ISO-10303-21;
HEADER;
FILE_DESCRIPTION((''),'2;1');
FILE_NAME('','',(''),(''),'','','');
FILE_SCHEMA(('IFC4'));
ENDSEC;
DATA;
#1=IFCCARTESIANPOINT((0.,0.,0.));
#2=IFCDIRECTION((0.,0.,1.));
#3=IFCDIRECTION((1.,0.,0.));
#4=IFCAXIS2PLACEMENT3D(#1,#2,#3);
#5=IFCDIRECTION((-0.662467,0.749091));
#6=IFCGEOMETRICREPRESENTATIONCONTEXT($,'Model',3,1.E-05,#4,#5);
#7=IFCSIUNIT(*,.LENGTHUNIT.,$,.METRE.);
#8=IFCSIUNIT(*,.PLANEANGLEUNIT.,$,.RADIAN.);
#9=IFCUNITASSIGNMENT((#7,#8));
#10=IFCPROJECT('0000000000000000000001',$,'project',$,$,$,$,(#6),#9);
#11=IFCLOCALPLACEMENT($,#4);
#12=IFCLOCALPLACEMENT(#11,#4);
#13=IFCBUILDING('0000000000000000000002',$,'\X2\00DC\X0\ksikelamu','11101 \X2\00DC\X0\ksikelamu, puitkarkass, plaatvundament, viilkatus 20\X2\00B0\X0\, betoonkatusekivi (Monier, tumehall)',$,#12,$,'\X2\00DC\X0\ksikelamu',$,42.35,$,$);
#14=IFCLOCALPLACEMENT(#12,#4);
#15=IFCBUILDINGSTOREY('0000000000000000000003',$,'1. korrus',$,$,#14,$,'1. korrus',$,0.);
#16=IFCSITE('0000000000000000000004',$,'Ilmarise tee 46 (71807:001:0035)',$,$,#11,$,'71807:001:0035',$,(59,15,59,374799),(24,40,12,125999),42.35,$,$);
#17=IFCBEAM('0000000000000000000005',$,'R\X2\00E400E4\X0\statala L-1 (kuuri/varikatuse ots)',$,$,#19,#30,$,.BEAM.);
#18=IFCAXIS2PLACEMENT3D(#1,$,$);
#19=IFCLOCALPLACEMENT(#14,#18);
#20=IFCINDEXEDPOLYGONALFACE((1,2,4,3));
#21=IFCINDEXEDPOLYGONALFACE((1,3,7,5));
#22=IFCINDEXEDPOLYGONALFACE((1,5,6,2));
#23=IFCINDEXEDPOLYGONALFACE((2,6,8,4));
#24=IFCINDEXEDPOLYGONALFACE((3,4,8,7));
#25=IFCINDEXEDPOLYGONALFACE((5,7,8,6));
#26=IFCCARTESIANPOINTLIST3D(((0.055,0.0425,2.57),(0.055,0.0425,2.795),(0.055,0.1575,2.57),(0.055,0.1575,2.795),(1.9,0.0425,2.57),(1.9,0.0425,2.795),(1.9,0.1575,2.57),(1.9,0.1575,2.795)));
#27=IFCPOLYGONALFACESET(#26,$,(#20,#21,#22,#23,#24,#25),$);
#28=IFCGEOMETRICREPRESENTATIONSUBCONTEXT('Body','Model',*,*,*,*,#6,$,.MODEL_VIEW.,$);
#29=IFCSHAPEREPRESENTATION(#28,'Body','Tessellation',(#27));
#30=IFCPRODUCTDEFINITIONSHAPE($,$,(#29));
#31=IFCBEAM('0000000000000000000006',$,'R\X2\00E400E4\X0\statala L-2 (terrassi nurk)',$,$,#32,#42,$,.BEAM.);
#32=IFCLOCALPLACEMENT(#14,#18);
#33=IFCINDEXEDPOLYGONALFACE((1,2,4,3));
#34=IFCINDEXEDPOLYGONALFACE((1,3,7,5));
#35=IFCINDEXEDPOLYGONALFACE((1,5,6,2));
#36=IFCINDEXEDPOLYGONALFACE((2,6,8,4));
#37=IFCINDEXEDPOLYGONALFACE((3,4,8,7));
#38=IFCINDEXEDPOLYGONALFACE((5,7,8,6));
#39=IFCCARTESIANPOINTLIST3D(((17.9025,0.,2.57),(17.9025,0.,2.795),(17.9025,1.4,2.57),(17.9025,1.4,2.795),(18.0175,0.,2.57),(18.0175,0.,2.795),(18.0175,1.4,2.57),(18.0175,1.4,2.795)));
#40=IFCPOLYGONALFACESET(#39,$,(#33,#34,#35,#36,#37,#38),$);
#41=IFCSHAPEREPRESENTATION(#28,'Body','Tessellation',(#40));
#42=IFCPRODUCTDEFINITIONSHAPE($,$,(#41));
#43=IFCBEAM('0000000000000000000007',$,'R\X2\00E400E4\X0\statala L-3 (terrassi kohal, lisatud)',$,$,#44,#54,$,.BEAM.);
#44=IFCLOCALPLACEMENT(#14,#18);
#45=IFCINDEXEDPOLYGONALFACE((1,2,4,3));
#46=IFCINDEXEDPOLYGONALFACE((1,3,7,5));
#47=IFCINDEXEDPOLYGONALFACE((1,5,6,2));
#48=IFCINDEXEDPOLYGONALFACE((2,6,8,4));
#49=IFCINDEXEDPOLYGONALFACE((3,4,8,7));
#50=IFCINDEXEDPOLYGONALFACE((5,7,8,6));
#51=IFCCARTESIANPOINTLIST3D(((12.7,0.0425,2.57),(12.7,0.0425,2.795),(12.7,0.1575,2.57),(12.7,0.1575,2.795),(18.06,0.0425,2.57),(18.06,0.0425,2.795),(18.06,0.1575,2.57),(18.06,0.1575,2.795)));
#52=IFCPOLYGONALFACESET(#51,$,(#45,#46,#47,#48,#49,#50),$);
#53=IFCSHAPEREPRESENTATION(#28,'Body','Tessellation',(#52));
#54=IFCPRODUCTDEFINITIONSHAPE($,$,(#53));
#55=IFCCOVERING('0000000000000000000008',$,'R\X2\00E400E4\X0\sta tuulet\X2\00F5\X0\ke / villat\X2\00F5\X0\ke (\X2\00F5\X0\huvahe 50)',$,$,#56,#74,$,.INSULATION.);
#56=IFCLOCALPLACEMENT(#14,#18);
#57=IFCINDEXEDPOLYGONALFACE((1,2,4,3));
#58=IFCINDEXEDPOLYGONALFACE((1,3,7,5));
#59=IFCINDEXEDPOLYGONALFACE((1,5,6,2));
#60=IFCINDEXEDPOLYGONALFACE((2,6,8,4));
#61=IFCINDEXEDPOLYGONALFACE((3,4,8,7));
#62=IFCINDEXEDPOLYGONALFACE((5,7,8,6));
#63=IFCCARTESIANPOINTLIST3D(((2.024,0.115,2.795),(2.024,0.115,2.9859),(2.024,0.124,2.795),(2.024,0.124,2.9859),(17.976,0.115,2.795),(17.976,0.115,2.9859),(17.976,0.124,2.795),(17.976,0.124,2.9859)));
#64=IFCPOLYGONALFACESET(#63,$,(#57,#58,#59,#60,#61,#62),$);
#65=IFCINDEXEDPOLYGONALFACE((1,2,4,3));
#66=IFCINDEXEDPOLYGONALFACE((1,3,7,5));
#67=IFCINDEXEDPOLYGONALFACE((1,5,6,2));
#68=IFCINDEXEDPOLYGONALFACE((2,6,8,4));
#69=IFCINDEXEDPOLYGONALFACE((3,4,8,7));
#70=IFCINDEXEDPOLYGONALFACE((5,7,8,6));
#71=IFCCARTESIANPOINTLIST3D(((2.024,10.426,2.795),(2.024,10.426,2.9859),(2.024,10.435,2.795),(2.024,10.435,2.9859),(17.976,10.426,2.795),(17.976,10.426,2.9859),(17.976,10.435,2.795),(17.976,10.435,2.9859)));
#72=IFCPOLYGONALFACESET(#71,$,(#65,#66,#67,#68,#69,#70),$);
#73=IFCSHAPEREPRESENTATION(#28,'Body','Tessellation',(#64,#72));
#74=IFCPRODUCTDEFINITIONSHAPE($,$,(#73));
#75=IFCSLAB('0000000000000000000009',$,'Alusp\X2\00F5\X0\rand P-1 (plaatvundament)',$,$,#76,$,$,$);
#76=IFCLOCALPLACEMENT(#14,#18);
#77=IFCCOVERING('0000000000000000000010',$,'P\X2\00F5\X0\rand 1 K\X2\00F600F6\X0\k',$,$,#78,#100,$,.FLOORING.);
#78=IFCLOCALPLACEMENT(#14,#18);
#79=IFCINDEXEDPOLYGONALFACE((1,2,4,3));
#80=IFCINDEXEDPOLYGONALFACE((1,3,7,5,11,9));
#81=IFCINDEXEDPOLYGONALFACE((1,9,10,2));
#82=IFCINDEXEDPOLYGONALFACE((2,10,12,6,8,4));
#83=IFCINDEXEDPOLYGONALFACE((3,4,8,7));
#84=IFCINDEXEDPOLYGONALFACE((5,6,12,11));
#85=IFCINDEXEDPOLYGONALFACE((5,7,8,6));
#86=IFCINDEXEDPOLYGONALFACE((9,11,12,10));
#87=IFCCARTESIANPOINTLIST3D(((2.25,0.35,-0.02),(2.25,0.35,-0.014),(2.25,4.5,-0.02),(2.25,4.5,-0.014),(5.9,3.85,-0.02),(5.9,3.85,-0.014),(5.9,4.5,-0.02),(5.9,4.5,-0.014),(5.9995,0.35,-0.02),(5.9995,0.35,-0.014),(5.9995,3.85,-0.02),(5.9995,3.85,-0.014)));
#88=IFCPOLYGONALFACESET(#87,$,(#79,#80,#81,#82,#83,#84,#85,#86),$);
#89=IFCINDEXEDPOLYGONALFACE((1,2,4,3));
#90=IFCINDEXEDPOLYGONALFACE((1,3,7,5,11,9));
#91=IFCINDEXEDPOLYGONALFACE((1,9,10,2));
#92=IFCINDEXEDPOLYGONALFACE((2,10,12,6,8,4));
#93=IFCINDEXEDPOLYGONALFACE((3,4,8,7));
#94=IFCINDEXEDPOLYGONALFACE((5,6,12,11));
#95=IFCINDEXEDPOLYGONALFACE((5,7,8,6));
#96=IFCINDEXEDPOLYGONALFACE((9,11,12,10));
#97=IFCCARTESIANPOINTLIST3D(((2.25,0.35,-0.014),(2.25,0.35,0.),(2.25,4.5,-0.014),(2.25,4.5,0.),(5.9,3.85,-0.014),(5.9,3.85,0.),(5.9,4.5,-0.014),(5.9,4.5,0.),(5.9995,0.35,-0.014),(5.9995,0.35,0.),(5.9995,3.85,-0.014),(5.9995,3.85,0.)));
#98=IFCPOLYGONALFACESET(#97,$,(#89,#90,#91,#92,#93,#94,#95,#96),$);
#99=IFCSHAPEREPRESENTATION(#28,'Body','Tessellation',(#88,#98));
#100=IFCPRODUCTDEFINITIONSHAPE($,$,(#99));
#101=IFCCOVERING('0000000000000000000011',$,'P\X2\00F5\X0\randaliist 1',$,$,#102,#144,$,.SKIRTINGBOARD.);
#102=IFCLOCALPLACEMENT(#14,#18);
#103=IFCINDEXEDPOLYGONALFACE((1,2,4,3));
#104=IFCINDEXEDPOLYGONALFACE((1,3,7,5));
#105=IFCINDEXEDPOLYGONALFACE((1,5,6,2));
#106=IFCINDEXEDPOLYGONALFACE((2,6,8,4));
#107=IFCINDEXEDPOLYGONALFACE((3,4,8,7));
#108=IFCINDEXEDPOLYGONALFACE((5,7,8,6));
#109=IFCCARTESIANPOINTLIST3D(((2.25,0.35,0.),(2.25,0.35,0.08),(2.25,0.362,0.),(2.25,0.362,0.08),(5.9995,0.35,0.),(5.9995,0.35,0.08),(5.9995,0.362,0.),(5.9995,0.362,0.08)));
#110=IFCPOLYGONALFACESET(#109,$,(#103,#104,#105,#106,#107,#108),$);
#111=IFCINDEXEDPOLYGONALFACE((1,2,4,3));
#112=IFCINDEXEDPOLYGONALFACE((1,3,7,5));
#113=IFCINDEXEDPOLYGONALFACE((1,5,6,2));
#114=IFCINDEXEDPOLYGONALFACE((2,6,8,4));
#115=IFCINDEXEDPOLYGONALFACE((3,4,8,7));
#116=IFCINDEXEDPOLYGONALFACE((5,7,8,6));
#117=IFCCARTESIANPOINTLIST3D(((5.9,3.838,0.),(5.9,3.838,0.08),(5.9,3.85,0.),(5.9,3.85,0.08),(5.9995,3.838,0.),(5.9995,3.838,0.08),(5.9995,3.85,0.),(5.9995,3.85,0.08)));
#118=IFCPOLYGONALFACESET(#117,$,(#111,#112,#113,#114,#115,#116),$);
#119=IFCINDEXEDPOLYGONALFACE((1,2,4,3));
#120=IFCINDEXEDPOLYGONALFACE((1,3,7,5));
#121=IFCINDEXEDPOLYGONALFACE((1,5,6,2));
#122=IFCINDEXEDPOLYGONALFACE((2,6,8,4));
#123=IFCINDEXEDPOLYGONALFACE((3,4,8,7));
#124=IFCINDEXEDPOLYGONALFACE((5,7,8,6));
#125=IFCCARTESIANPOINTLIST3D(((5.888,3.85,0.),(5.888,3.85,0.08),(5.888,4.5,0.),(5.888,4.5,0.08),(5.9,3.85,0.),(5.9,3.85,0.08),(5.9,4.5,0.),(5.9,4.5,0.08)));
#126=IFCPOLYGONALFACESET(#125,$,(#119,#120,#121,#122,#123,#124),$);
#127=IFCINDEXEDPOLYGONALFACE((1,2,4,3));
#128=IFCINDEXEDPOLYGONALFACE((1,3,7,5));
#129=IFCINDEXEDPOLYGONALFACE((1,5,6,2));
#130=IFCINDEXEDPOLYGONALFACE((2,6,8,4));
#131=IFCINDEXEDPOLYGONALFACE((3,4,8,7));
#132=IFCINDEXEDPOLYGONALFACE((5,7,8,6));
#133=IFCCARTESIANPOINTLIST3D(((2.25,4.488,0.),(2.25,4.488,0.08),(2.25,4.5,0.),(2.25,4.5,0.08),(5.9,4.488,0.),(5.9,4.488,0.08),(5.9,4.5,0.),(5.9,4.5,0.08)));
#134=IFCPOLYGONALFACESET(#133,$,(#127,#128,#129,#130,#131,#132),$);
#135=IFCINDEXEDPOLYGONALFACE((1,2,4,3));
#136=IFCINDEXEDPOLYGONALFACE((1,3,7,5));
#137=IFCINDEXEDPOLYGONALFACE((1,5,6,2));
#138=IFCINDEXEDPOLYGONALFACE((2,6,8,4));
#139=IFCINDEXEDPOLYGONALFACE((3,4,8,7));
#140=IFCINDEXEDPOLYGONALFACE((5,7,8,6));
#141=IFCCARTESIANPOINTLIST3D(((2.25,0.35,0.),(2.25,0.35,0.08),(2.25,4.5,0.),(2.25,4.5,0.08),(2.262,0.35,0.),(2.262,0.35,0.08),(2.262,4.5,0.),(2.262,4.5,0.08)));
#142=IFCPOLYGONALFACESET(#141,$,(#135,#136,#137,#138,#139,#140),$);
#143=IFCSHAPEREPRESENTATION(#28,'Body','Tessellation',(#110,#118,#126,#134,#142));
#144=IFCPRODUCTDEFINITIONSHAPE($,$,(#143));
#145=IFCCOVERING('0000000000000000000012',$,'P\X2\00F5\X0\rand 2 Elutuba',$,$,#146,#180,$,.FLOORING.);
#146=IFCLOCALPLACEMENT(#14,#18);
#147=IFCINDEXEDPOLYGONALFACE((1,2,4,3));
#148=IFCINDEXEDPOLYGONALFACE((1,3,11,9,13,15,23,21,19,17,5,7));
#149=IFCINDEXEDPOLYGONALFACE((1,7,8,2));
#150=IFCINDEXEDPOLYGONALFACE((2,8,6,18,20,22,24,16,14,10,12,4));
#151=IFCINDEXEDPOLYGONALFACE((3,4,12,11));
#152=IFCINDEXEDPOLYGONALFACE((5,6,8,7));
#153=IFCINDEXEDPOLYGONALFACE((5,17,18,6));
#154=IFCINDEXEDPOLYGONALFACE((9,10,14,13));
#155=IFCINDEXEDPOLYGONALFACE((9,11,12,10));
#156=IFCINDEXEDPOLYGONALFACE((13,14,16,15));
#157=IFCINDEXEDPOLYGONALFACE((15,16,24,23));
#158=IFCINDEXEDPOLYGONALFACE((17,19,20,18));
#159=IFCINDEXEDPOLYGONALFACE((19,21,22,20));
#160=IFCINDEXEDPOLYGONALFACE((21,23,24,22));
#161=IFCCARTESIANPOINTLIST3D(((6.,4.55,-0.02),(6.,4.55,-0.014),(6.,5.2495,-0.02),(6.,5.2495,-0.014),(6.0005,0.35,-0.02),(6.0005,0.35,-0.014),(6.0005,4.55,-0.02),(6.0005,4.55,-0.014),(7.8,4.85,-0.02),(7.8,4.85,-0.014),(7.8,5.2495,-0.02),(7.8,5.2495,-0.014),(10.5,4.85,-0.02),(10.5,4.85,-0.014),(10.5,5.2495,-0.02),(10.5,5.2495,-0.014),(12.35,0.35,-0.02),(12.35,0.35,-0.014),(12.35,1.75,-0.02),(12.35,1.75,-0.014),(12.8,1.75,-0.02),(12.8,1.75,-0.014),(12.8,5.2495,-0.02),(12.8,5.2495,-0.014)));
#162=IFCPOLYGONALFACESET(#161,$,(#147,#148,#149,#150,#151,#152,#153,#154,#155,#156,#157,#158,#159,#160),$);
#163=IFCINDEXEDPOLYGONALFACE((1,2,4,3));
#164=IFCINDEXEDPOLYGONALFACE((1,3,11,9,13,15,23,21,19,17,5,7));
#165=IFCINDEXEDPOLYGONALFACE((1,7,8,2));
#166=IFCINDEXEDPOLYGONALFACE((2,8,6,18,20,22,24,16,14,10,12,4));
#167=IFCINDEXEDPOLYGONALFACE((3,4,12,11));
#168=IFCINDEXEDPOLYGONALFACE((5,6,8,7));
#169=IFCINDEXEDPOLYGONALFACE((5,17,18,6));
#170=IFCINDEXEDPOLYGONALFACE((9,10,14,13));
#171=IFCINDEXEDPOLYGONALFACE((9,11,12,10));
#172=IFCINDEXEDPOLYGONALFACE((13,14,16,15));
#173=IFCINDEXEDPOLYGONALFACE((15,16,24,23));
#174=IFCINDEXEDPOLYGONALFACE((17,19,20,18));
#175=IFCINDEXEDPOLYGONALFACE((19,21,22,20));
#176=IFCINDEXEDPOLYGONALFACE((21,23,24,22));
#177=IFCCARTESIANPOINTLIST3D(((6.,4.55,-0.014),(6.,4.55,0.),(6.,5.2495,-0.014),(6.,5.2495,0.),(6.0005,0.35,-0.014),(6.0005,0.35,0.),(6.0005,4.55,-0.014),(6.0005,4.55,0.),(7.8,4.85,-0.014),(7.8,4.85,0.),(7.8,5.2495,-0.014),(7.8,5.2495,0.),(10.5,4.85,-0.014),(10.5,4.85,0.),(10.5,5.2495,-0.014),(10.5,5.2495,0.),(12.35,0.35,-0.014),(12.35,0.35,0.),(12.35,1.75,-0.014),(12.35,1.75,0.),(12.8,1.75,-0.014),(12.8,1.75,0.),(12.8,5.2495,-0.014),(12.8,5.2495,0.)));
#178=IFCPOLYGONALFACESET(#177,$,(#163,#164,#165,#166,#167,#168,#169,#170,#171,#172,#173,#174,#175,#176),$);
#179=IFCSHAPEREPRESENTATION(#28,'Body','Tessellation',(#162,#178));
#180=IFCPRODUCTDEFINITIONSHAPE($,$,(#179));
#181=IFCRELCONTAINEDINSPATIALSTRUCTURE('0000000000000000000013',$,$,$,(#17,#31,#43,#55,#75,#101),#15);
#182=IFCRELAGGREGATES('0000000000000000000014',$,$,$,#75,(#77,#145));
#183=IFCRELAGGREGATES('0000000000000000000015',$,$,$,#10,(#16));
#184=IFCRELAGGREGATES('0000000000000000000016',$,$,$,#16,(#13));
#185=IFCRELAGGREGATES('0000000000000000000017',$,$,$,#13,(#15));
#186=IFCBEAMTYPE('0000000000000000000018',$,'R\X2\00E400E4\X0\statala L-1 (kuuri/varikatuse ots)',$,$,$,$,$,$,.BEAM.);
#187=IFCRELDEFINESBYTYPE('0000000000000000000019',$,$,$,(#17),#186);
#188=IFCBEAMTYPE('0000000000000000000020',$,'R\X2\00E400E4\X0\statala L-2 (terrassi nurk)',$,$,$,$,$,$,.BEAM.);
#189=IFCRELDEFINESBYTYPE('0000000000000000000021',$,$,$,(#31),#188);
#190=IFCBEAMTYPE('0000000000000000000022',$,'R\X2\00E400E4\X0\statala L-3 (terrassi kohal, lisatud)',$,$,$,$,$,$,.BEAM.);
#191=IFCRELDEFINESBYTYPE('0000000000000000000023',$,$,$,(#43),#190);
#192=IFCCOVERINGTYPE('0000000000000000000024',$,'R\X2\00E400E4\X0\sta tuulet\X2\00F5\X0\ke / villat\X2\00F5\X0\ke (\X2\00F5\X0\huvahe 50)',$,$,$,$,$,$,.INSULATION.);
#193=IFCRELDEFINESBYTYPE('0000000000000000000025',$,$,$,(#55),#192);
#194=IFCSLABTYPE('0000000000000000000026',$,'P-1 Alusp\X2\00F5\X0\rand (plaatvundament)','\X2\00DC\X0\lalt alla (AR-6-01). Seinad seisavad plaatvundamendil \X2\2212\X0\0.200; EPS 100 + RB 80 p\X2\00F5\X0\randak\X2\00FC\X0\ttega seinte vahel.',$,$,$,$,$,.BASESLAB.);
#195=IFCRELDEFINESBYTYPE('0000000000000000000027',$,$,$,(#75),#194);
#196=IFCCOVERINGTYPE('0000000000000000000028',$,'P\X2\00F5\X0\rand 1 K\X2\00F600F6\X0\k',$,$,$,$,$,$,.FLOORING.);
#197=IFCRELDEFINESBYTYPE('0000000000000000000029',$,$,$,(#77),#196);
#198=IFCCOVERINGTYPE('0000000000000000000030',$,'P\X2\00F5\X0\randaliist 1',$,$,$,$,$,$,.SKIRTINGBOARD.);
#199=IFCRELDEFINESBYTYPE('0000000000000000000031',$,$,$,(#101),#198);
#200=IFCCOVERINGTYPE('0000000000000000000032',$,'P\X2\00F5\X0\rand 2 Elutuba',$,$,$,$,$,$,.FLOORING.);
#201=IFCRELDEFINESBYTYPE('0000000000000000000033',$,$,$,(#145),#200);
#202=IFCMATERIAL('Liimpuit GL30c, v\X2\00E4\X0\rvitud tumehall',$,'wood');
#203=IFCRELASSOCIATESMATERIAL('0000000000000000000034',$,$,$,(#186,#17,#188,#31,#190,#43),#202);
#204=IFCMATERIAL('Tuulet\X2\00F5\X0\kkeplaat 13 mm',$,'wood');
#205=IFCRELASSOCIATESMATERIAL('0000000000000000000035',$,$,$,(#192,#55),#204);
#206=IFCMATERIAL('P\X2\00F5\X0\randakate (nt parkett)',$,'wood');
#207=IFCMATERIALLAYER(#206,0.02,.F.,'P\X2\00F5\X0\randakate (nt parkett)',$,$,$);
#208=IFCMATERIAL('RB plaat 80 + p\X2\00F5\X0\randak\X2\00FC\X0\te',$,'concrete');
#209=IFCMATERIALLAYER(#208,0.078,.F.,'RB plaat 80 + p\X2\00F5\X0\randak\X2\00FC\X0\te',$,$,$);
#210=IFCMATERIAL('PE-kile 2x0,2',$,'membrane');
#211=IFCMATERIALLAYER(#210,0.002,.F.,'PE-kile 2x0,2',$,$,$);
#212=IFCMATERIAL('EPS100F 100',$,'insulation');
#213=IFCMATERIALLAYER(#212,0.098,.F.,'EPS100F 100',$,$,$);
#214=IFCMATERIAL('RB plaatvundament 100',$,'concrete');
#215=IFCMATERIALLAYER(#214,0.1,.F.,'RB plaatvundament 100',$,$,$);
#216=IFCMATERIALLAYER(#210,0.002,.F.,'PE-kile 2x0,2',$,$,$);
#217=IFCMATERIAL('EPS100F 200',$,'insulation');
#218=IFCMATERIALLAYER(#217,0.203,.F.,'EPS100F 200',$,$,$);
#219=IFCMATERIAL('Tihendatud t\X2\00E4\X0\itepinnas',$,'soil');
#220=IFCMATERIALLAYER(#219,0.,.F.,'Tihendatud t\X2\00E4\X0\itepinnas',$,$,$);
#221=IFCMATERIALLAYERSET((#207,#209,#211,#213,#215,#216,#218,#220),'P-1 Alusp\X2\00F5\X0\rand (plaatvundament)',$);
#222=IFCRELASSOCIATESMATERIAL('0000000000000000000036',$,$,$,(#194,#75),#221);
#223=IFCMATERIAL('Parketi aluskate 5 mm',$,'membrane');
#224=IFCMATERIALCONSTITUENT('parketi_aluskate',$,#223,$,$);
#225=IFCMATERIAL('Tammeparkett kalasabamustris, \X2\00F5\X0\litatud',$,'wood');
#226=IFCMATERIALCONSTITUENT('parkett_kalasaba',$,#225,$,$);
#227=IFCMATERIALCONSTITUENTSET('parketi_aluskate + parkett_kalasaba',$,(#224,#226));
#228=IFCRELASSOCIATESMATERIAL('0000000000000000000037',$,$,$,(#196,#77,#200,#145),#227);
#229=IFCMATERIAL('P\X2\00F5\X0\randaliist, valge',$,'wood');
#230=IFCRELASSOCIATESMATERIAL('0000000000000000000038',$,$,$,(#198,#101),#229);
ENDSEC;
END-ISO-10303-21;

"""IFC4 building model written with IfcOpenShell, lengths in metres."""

from ifc_helpers import new_model, si_unit, direction, frame, origin_with_axes, place, context, subcontext, project, spatial, indexed_curve, outline, extrude, material, layer, layer_set, layer_usage, constituent, constituent_set, type_object, element, aggregate, save


model = new_model("IFC4")

# Units and contexts
model_context = context("Model", 3, precision=1e-05, world=origin_with_axes(), true_north=direction((-0.662467, 0.749091)))
body_context = subcontext(model_context, "Body", "Model", "MODEL_VIEW")
ifc_project = project(units=[si_unit("LENGTHUNIT", "METRE"), si_unit("PLANEANGLEUNIT", "RADIAN")], contexts=[model_context])

# Site, building, storey
site_placement = place(None, origin_with_axes())
site = spatial("IfcSite", under=ifc_project, at=site_placement, Name="Ilmarise tee 46 (71807:001:0035)", LongName="71807:001:0035", RefLatitude=(59, 15, 59, 374799), RefLongitude=(24, 40, 12, 125999), RefElevation=42.35)
building_placement = place(site_placement, origin_with_axes())
building = spatial("IfcBuilding", under=site, at=building_placement, Name="Üksikelamu", Description="11101 Üksikelamu, puitkarkass, plaatvundament, viilkatus 20°, betoonkatusekivi (Monier, tumehall)", LongName="Üksikelamu", ElevationOfRefHeight=42.35)
storey_placement = place(building_placement, origin_with_axes())
storey = spatial("IfcBuildingStorey", under=building, at=storey_placement, Name="1. korrus", LongName="1. korrus", Elevation=0.0)

# Beams
ifc_material_1 = material(Name="Liimpuit GL30c, värvitud tumehall", Category="wood")
beam_type_1 = type_object("IfcBeamType", Name="Räästatala L-1 (kuuri/varikatuse ots)", PredefinedType="BEAM", material=ifc_material_1)
beam_1_placement = place(storey_placement, origin_with_axes())
element("IfcBeam", 1, at=beam_1_placement, inside=storey, type_object=beam_type_1, material=ifc_material_1, Name="Räästatala L-1 (kuuri/varikatuse ots)", PredefinedType="BEAM", context=body_context, shape_type="SweptSolid", body=[
    extrude(outline(indexed_curve([(0.055, 0.1575), (1.9, 0.1575), (1.9, 0.0425), (0.055, 0.0425), (0.055, 0.1575)], self_intersect=False)), frame((0.0, 0.0, 2.57), z_axis=(0.0, 0.0, 1.0), x_axis=(1.0, 0.0, 0.0)), (0.0, 0.0, 1.0), 0.225),
])
beam_type_2 = type_object("IfcBeamType", Name="Räästatala L-2 (terrassi nurk)", PredefinedType="BEAM", material=ifc_material_1)
beam_2_placement = place(storey_placement, origin_with_axes())
element("IfcBeam", 2, at=beam_2_placement, inside=storey, type_object=beam_type_2, material=ifc_material_1, Name="Räästatala L-2 (terrassi nurk)", PredefinedType="BEAM", context=body_context, shape_type="SweptSolid", body=[
    extrude(outline(indexed_curve([(17.9025, 0.0), (17.9025, 1.4), (18.0175, 1.4), (18.0175, 0.0), (17.9025, 0.0)], self_intersect=False)), frame((0.0, 0.0, 2.57), z_axis=(0.0, 0.0, 1.0), x_axis=(1.0, 0.0, 0.0)), (0.0, 0.0, 1.0), 0.225),
])
beam_type_3 = type_object("IfcBeamType", Name="Räästatala L-3 (terrassi kohal, lisatud)", PredefinedType="BEAM", material=ifc_material_1)
beam_3_placement = place(storey_placement, origin_with_axes())
element("IfcBeam", 3, at=beam_3_placement, inside=storey, type_object=beam_type_3, material=ifc_material_1, Name="Räästatala L-3 (terrassi kohal, lisatud)", PredefinedType="BEAM", context=body_context, shape_type="SweptSolid", body=[
    extrude(outline(indexed_curve([(12.7, 0.1575), (18.06, 0.1575), (18.06, 0.0425), (12.7, 0.0425), (12.7, 0.1575)], self_intersect=False)), frame((0.0, 0.0, 2.57), z_axis=(0.0, 0.0, 1.0), x_axis=(1.0, 0.0, 0.0)), (0.0, 0.0, 1.0), 0.225),
])

# Covering
ifc_material_2 = material(Name="Tuuletõkkeplaat 13 mm", Category="wood")
covering_type_1 = type_object("IfcCoveringType", Name="Räästa tuuletõke / villatõke (õhuvahe 50)", PredefinedType="INSULATION", material=ifc_material_2)
covering_1_placement = place(storey_placement, origin_with_axes())
element("IfcCovering", 4, at=covering_1_placement, inside=storey, type_object=covering_type_1, material=ifc_material_2, Name="Räästa tuuletõke / villatõke (õhuvahe 50)", PredefinedType="INSULATION", context=body_context, shape_type="SweptSolid", body=[
    extrude(outline(indexed_curve([(2.024, 0.115), (17.976, 0.115), (17.976, 0.124), (2.024, 0.124), (2.024, 0.115)], self_intersect=False)), frame((0.0, 0.0, 2.795), z_axis=(0.0, 0.0, 1.0), x_axis=(1.0, 0.0, 0.0)), (0.0, 0.0, 1.0), 0.1909),
    extrude(outline(indexed_curve([(2.024, 10.426), (17.976, 10.426), (17.976, 10.435), (2.024, 10.435), (2.024, 10.426)], self_intersect=False)), frame((0.0, 0.0, 2.795), z_axis=(0.0, 0.0, 1.0), x_axis=(1.0, 0.0, 0.0)), (0.0, 0.0, 1.0), 0.1909),
])

# Slab, covering
ifc_material_3 = material(Name="Põrandakate (nt parkett)", Category="wood")
ifc_layer_1 = layer(ifc_material_3, 0.02, ventilated=False, Name="Põrandakate (nt parkett)")
ifc_material_4 = material(Name="RB plaat 80 + põrandaküte", Category="concrete")
ifc_layer_2 = layer(ifc_material_4, 0.078, ventilated=False, Name="RB plaat 80 + põrandaküte")
ifc_material_5 = material(Name="PE-kile 2x0,2", Category="membrane")
ifc_layer_3 = layer(ifc_material_5, 0.002, ventilated=False, Name="PE-kile 2x0,2")
ifc_material_6 = material(Name="EPS100F 100", Category="insulation")
ifc_layer_4 = layer(ifc_material_6, 0.098, ventilated=False, Name="EPS100F 100")
ifc_material_7 = material(Name="RB plaatvundament 100", Category="concrete")
ifc_layer_5 = layer(ifc_material_7, 0.1, ventilated=False, Name="RB plaatvundament 100")
ifc_layer_6 = layer(ifc_material_5, 0.002, ventilated=False, Name="PE-kile 2x0,2")
ifc_material_8 = material(Name="EPS100F 200", Category="insulation")
ifc_layer_7 = layer(ifc_material_8, 0.203, ventilated=False, Name="EPS100F 200")
ifc_material_9 = material(Name="Tihendatud täitepinnas", Category="soil")
ifc_layer_8 = layer(ifc_material_9, 0.0, ventilated=False, Name="Tihendatud täitepinnas")
ifc_layer_set_1 = layer_set([ifc_layer_1, ifc_layer_2, ifc_layer_3, ifc_layer_4, ifc_layer_5, ifc_layer_6, ifc_layer_7, ifc_layer_8], Name="P-1 Aluspõrand (plaatvundament)")
ifc_layer_usage_1 = layer_usage(ifc_layer_set_1, "AXIS3", "NEGATIVE", 0.0)
slab_type = type_object("IfcSlabType", Name="P-1 Aluspõrand (plaatvundament)", Description="Ülalt alla (AR-6-01). Seinad seisavad plaatvundamendil −0.200; EPS 100 + RB 80 põrandaküttega seinte vahel.", PredefinedType="BASESLAB", material=ifc_layer_set_1)
slab_placement = place(storey_placement, origin_with_axes())
slab = element("IfcSlab", 5, at=slab_placement, inside=storey, type_object=slab_type, material=ifc_layer_usage_1, Name="Aluspõrand P-1 (plaatvundament)")
ifc_material_10 = material(Name="Parketi aluskate 5 mm", Category="membrane")
ifc_constituent_1 = constituent(ifc_material_10, Name="parketi_aluskate")
ifc_material_11 = material(Name="Tammeparkett kalasabamustris, õlitatud", Category="wood")
ifc_constituent_2 = constituent(ifc_material_11, Name="parkett_kalasaba")
ifc_constituent_set_1 = constituent_set(constituents=[ifc_constituent_1, ifc_constituent_2], Name="parketi_aluskate + parkett_kalasaba")
covering_type_2 = type_object("IfcCoveringType", Name="Põrand 1 Köök", PredefinedType="FLOORING", material=ifc_constituent_set_1)
covering_2_placement = place(slab_placement, origin_with_axes())
covering_2 = element("IfcCovering", 6, at=covering_2_placement, type_object=covering_type_2, material=ifc_constituent_set_1, Name="Põrand 1 Köök", PredefinedType="FLOORING", context=body_context, shape_type="SweptSolid", body=[
    extrude(outline(indexed_curve([(2.25, 0.35), (2.25, 4.5), (5.9, 4.5), (5.9, 3.85), (5.9995, 3.85), (5.9995, 0.35), (2.25, 0.35)], self_intersect=False)), frame((0.0, 0.0, -0.02), z_axis=(0.0, 0.0, 1.0), x_axis=(1.0, 0.0, 0.0)), (0.0, 0.0, 1.0), 0.006),
    extrude(outline(indexed_curve([(2.25, 0.35), (2.25, 4.5), (5.9, 4.5), (5.9, 3.85), (5.9995, 3.85), (5.9995, 0.35), (2.25, 0.35)], self_intersect=False)), frame((0.0, 0.0, -0.014), z_axis=(0.0, 0.0, 1.0), x_axis=(1.0, 0.0, 0.0)), (0.0, 0.0, 1.0), 0.014),
])

# Coverings
ifc_material_12 = material(Name="Põrandaliist, valge", Category="wood")
covering_type_3 = type_object("IfcCoveringType", Name="Põrandaliist 1", PredefinedType="SKIRTINGBOARD", material=ifc_material_12)
covering_3_placement = place(storey_placement, origin_with_axes())
element("IfcCovering", 7, at=covering_3_placement, inside=storey, type_object=covering_type_3, material=ifc_material_12, Name="Põrandaliist 1", PredefinedType="SKIRTINGBOARD", context=body_context, shape_type="SweptSolid", body=[
    extrude(outline(indexed_curve([(2.25, 0.362), (5.9995, 0.362), (5.9995, 0.35), (2.25, 0.35), (2.25, 0.362)], self_intersect=False)), origin_with_axes(), (0.0, 0.0, 1.0), 0.08),
    extrude(outline(indexed_curve([(5.9995, 3.838), (5.9, 3.838), (5.9, 3.85), (5.9995, 3.85), (5.9995, 3.838)], self_intersect=False)), origin_with_axes(), (0.0, 0.0, 1.0), 0.08),
    extrude(outline(indexed_curve([(5.888, 3.85), (5.888, 4.5), (5.9, 4.5), (5.9, 3.85), (5.888, 3.85)], self_intersect=False)), origin_with_axes(), (0.0, 0.0, 1.0), 0.08),
    extrude(outline(indexed_curve([(5.9, 4.488), (2.25, 4.488), (2.25, 4.5), (5.9, 4.5), (5.9, 4.488)], self_intersect=False)), origin_with_axes(), (0.0, 0.0, 1.0), 0.08),
    extrude(outline(indexed_curve([(2.262, 4.5), (2.262, 0.35), (2.25, 0.35), (2.25, 4.5), (2.262, 4.5)], self_intersect=False)), origin_with_axes(), (0.0, 0.0, 1.0), 0.08),
])
covering_type_4 = type_object("IfcCoveringType", Name="Põrand 2 Elutuba", PredefinedType="FLOORING", material=ifc_constituent_set_1)
covering_4_placement = place(slab_placement, origin_with_axes())
covering_4 = element("IfcCovering", 8, at=covering_4_placement, type_object=covering_type_4, material=ifc_constituent_set_1, Name="Põrand 2 Elutuba", PredefinedType="FLOORING", context=body_context, shape_type="SweptSolid", body=[
    extrude(outline(indexed_curve([(12.35, 0.35), (6.0005, 0.35), (6.0005, 4.55), (6.0, 4.55), (6.0, 5.2495), (7.8, 5.2495), (7.8, 4.85), (10.5, 4.85), (10.5, 5.2495), (12.8, 5.2495), (12.8, 1.75), (12.35, 1.75), (12.35, 0.35)], self_intersect=False)), frame((0.0, 0.0, -0.02), z_axis=(0.0, 0.0, 1.0), x_axis=(1.0, 0.0, 0.0)), (0.0, 0.0, 1.0), 0.006),
    extrude(outline(indexed_curve([(12.35, 0.35), (6.0005, 0.35), (6.0005, 4.55), (6.0, 4.55), (6.0, 5.2495), (7.8, 5.2495), (7.8, 4.85), (10.5, 4.85), (10.5, 5.2495), (12.8, 5.2495), (12.8, 1.75), (12.35, 1.75), (12.35, 0.35)], self_intersect=False)), frame((0.0, 0.0, -0.014), z_axis=(0.0, 0.0, 1.0), x_axis=(1.0, 0.0, 0.0)), (0.0, 0.0, 1.0), 0.014),
])

aggregate(slab, [covering_2, covering_4])

save(model, "model.ifc")
